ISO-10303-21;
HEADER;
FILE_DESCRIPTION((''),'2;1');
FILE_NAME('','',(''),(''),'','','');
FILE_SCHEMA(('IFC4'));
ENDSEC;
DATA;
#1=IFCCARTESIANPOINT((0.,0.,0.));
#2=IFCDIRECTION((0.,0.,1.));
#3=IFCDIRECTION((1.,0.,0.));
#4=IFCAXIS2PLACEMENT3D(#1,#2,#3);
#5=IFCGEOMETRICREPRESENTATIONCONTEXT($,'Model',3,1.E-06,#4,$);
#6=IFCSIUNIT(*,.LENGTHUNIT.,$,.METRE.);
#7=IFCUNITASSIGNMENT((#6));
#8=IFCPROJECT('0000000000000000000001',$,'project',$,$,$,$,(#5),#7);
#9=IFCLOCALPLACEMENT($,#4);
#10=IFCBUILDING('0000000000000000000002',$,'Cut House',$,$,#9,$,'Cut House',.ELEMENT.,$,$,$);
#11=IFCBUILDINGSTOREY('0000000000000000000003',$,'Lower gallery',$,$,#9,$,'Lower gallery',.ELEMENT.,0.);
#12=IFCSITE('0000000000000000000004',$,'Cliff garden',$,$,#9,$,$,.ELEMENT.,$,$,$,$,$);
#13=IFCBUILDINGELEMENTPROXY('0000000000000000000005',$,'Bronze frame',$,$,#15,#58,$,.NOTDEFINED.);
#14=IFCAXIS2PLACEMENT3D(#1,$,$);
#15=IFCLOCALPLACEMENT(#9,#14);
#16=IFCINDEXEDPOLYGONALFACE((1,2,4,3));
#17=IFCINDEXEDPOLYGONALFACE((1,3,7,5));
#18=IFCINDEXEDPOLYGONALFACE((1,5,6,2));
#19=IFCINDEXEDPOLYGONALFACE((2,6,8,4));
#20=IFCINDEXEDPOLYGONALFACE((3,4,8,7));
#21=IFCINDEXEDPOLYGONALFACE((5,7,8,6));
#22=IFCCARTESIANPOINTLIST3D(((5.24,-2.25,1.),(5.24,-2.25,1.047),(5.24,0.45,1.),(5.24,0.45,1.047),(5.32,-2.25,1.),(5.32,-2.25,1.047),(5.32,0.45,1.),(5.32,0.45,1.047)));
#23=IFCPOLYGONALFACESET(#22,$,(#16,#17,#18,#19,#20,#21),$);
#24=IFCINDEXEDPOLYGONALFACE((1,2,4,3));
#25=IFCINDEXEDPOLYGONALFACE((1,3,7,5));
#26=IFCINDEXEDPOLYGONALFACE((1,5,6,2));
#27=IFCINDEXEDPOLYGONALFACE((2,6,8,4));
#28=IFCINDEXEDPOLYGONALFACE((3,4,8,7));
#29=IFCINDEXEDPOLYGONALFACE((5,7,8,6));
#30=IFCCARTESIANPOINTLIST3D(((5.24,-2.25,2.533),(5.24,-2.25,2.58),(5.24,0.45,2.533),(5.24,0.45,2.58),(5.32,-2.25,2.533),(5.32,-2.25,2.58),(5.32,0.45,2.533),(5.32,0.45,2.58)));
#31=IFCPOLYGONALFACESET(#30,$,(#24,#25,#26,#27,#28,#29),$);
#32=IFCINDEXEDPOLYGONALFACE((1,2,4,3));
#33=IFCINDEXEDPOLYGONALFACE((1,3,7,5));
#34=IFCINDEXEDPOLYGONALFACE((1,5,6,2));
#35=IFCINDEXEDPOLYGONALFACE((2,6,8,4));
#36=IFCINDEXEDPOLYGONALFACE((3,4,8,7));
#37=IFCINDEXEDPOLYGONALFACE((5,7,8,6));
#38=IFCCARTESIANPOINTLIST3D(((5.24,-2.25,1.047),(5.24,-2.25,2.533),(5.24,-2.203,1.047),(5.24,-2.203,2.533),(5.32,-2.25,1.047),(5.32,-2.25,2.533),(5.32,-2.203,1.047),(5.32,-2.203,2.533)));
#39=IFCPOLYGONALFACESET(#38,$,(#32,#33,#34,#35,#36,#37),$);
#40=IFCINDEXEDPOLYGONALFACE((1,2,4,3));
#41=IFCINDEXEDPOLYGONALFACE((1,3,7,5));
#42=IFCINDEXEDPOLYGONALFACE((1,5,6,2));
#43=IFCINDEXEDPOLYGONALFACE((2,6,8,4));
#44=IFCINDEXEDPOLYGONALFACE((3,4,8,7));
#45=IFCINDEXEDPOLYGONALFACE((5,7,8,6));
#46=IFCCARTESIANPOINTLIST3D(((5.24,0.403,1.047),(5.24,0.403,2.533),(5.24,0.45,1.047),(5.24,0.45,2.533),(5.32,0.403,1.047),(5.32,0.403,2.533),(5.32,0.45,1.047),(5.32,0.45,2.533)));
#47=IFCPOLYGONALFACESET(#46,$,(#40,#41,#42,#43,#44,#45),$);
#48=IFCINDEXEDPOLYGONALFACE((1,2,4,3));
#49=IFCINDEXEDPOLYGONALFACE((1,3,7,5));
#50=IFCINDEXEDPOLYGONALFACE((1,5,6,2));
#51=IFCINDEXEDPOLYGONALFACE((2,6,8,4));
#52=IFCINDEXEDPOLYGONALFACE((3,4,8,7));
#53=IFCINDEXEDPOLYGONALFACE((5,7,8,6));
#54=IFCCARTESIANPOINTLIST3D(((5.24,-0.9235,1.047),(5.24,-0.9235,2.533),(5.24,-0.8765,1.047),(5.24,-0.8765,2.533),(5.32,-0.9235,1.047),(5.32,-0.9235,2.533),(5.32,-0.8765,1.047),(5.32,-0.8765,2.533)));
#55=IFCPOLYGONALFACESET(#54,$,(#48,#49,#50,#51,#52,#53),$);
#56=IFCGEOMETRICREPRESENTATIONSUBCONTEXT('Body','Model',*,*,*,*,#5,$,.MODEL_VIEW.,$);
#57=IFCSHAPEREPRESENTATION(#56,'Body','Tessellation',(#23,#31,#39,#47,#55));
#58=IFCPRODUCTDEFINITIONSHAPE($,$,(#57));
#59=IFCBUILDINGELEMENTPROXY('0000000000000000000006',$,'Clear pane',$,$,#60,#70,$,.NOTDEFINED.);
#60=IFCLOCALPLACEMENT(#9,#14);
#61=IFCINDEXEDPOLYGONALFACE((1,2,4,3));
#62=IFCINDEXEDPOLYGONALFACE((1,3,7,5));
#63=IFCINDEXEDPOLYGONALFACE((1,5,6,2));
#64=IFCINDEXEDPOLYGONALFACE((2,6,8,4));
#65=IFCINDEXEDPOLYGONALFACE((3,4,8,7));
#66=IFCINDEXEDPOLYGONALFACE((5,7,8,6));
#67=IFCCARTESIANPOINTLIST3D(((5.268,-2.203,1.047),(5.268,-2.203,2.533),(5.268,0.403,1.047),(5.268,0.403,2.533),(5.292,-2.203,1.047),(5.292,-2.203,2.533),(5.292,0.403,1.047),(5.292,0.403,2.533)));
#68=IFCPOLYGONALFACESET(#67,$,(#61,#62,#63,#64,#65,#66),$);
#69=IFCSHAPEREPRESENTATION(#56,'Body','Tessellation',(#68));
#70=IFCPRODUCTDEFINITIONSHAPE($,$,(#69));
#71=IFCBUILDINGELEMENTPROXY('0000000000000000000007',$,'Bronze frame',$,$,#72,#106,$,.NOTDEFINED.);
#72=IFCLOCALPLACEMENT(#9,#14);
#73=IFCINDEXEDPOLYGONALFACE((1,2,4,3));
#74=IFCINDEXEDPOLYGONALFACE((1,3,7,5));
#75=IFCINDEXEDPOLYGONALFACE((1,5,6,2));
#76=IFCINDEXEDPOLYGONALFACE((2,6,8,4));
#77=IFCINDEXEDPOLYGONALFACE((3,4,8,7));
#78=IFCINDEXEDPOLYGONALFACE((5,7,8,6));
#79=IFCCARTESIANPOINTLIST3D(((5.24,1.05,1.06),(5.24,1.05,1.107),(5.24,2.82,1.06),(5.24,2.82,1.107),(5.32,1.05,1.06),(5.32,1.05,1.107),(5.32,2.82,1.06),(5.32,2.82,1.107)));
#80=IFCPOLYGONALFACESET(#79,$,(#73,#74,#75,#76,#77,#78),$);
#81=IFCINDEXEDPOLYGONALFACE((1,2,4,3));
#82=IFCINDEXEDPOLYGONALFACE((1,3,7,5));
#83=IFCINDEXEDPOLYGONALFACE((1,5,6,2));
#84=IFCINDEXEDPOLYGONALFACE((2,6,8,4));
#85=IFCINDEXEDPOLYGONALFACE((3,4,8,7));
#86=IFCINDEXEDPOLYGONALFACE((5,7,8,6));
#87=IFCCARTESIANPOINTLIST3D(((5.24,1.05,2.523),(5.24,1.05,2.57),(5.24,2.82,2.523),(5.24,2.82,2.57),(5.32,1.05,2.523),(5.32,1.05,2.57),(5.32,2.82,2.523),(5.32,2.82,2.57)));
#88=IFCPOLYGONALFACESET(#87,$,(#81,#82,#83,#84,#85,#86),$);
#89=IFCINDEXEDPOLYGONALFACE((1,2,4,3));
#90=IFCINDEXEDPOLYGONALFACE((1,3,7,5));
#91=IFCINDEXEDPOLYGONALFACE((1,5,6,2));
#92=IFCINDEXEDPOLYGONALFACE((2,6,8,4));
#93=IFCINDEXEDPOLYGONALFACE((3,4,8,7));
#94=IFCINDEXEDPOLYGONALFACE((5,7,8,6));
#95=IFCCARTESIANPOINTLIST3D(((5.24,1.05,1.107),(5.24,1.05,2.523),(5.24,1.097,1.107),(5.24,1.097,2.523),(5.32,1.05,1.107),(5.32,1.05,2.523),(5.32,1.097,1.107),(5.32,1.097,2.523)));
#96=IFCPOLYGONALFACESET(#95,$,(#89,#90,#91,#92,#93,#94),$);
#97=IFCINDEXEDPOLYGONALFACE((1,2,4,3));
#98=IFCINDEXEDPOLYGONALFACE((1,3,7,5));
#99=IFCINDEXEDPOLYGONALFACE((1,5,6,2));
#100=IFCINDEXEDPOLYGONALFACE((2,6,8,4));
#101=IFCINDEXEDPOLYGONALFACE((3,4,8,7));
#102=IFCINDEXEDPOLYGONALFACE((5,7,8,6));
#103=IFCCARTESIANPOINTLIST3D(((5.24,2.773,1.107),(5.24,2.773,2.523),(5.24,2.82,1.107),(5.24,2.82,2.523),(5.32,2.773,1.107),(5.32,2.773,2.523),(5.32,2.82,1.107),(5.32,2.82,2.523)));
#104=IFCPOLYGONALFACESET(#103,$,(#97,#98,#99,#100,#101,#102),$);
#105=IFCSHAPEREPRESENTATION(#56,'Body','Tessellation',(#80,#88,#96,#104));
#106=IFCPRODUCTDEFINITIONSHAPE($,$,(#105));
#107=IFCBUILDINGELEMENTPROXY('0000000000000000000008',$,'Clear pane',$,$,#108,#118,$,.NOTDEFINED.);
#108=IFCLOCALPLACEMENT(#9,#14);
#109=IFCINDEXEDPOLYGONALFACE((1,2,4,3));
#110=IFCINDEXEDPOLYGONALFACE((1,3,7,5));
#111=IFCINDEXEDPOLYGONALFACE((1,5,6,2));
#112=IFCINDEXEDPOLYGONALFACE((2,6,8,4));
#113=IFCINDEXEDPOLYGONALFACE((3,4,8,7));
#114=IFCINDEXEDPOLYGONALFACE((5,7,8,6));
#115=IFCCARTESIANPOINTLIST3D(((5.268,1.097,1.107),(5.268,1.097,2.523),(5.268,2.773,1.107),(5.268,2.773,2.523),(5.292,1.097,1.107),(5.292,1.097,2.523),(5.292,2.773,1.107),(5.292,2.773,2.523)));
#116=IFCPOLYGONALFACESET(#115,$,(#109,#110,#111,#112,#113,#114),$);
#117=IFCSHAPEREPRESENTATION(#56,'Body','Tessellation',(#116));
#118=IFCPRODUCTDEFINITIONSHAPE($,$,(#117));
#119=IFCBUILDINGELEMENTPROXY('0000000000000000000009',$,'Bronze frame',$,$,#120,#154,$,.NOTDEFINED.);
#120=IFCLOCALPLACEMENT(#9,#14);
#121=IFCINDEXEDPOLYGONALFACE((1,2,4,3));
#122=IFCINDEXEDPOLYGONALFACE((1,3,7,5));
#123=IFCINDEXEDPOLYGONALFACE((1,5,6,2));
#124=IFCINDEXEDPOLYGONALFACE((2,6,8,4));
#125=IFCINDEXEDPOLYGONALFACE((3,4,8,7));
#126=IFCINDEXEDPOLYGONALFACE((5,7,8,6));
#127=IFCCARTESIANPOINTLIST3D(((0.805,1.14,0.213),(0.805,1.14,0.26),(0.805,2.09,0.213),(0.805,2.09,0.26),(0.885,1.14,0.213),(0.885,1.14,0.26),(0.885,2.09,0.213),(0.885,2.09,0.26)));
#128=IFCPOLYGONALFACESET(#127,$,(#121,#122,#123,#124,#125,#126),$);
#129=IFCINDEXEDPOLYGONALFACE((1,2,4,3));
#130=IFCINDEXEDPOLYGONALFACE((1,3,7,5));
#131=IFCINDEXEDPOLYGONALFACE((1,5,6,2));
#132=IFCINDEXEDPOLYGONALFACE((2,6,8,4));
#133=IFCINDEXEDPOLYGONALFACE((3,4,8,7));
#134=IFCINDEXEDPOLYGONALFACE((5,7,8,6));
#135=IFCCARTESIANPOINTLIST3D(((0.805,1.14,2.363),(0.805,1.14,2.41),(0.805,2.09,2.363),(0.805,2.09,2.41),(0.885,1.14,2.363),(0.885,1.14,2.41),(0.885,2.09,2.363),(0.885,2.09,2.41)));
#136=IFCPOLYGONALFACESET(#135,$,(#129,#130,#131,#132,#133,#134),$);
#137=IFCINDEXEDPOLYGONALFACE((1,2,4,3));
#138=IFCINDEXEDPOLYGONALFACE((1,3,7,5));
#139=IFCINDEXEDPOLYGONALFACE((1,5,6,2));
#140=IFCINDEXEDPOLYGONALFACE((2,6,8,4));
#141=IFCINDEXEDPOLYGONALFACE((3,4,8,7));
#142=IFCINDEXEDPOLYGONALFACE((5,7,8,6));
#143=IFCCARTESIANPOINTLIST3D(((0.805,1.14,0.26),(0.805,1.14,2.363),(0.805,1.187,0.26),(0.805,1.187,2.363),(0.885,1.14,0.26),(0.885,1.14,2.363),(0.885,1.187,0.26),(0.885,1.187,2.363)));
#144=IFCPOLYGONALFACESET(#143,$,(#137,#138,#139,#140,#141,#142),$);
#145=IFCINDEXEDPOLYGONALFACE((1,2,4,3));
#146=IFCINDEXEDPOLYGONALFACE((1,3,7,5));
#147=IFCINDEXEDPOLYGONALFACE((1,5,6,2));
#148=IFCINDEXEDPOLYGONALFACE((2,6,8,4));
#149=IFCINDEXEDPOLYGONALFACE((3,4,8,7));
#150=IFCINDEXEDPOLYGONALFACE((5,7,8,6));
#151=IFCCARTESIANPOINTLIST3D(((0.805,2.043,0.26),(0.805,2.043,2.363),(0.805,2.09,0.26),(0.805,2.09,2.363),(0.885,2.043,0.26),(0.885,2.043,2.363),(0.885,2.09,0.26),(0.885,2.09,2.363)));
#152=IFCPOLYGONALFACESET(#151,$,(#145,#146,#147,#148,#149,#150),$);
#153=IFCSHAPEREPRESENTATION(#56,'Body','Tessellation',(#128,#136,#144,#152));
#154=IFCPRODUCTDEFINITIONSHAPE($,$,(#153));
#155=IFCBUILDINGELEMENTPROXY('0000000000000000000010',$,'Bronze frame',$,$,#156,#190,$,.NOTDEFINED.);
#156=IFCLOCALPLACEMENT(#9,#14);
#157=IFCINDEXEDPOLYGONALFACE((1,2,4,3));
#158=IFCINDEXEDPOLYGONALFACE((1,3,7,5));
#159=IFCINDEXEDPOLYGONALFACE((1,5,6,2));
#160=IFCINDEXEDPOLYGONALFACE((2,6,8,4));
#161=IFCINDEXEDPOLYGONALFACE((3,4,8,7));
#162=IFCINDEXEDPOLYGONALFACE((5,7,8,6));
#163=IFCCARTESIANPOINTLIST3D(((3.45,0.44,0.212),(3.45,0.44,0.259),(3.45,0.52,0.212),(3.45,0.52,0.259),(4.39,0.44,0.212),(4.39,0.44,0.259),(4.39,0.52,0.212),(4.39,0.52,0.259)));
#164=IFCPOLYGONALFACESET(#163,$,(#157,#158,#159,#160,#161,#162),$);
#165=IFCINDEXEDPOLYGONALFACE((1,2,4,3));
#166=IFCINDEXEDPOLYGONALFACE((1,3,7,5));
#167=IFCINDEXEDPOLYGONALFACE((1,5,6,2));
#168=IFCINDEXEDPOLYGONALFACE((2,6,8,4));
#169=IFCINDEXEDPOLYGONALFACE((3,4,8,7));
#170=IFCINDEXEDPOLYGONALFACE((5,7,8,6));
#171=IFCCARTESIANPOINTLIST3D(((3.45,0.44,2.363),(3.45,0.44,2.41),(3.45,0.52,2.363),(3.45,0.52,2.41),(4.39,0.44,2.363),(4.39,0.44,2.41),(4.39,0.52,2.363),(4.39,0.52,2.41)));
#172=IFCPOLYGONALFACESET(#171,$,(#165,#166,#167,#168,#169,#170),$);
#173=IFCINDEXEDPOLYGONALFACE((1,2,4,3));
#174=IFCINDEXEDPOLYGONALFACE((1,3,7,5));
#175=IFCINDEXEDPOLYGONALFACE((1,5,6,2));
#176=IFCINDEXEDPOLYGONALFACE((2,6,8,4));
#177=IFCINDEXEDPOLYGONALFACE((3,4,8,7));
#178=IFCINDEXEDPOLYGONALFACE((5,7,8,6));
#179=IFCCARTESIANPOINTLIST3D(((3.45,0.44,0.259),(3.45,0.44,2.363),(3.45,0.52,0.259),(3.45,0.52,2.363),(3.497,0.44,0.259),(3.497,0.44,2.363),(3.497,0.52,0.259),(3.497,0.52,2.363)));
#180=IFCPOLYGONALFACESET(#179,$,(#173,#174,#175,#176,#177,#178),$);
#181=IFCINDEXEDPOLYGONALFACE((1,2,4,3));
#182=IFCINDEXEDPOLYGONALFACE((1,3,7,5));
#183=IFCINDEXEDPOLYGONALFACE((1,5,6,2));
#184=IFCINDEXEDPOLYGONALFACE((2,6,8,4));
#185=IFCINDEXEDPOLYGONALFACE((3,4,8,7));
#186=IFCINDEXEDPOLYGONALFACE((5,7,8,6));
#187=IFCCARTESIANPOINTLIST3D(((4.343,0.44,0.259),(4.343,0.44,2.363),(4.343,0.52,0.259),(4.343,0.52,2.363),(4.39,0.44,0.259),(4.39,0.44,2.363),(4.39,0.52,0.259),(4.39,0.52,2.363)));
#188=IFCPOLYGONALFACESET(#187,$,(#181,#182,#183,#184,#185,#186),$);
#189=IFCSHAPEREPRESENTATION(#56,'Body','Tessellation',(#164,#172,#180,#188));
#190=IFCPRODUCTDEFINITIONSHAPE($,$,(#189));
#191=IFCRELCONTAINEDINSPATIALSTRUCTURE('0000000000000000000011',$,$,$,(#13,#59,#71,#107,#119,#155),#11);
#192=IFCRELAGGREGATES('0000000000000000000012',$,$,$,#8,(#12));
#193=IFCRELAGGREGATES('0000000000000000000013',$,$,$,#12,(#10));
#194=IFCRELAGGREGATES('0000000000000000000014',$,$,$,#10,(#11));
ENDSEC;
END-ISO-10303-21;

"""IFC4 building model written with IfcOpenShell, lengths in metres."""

from ifc_helpers import new_model, si_unit, frame, origin_with_axes, place, context, subcontext, project, spatial, polyline, outline, extrude, element, save


model = new_model("IFC4")

# Units and contexts
model_context = context("Model", 3, precision=1e-06, world=origin_with_axes())
body_context = subcontext(model_context, "Body", "Model", "MODEL_VIEW")
ifc_project = project(units=[si_unit("LENGTHUNIT", "METRE")], contexts=[model_context])

# Site, building, storey
placement = place(None, origin_with_axes())
site = spatial("IfcSite", under=ifc_project, at=placement, Name="Cliff garden", CompositionType="ELEMENT")
building = spatial("IfcBuilding", under=site, at=placement, Name="Cut House", LongName="Cut House", CompositionType="ELEMENT")
storey = spatial("IfcBuildingStorey", under=building, at=placement, Name="Lower gallery", LongName="Lower gallery", CompositionType="ELEMENT", Elevation=0.0)

# Building element proxies
element("IfcBuildingElementProxy", 1, at=placement, inside=storey, Name="Bronze frame", PredefinedType="NOTDEFINED", context=body_context, shape_type="SweptSolid", body=[
    extrude(outline(polyline([(0.0, 0.0), (0.08, 0.0), (0.08, 2.7), (0.0, 2.7), (0.0, 0.0)])), frame((5.24, -2.25, 1.0), z_axis=(0.0, 0.0, 1.0), x_axis=(1.0, 0.0, 0.0)), (0.0, 0.0, 1.0), 0.047),
    extrude(outline(polyline([(0.0, 0.0), (0.08, 0.0), (0.08, 2.7), (0.0, 2.7), (0.0, 0.0)])), frame((5.24, -2.25, 2.533), z_axis=(0.0, 0.0, 1.0), x_axis=(1.0, 0.0, 0.0)), (0.0, 0.0, 1.0), 0.047),
    extrude(outline(polyline([(0.0, 0.0), (0.08, 0.0), (0.08, 0.047), (0.0, 0.047), (0.0, 0.0)])), frame((5.24, -2.25, 1.047), z_axis=(0.0, 0.0, 1.0), x_axis=(1.0, 0.0, 0.0)), (0.0, 0.0, 1.0), 1.486),
    extrude(outline(polyline([(0.0, 0.0), (0.08, 0.0), (0.08, 0.047), (0.0, 0.047), (0.0, 0.0)])), frame((5.24, 0.403, 1.047), z_axis=(0.0, 0.0, 1.0), x_axis=(1.0, 0.0, 0.0)), (0.0, 0.0, 1.0), 1.486),
    extrude(outline(polyline([(0.0, 0.0), (0.08, 0.0), (0.08, 0.047), (0.0, 0.047), (0.0, 0.0)])), frame((5.24, -0.9235, 1.047), z_axis=(0.0, 0.0, 1.0), x_axis=(1.0, 0.0, 0.0)), (0.0, 0.0, 1.0), 1.486),
])
element("IfcBuildingElementProxy", 2, at=placement, inside=storey, Name="Clear pane", PredefinedType="NOTDEFINED", context=body_context, shape_type="SweptSolid", body=[
    extrude(outline(polyline([(0.0, 0.0), (0.024, 0.0), (0.024, 2.606), (0.0, 2.606), (0.0, 0.0)])), frame((5.268, -2.203, 1.047), z_axis=(0.0, 0.0, 1.0), x_axis=(1.0, 0.0, 0.0)), (0.0, 0.0, 1.0), 1.486),
])
element("IfcBuildingElementProxy", 3, at=placement, inside=storey, Name="Bronze frame", PredefinedType="NOTDEFINED", context=body_context, shape_type="SweptSolid", body=[
    extrude(outline(polyline([(0.0, 0.0), (0.08, 0.0), (0.08, 1.77), (0.0, 1.77), (0.0, 0.0)])), frame((5.24, 1.05, 1.06), z_axis=(0.0, 0.0, 1.0), x_axis=(1.0, 0.0, 0.0)), (0.0, 0.0, 1.0), 0.047),
    extrude(outline(polyline([(0.0, 0.0), (0.08, 0.0), (0.08, 1.77), (0.0, 1.77), (0.0, 0.0)])), frame((5.24, 1.05, 2.523), z_axis=(0.0, 0.0, 1.0), x_axis=(1.0, 0.0, 0.0)), (0.0, 0.0, 1.0), 0.047),
    extrude(outline(polyline([(0.0, 0.0), (0.08, 0.0), (0.08, 0.047), (0.0, 0.047), (0.0, 0.0)])), frame((5.24, 1.05, 1.107), z_axis=(0.0, 0.0, 1.0), x_axis=(1.0, 0.0, 0.0)), (0.0, 0.0, 1.0), 1.416),
    extrude(outline(polyline([(0.0, 0.0), (0.08, 0.0), (0.08, 0.047), (0.0, 0.047), (0.0, 0.0)])), frame((5.24, 2.773, 1.107), z_axis=(0.0, 0.0, 1.0), x_axis=(1.0, 0.0, 0.0)), (0.0, 0.0, 1.0), 1.416),
])
element("IfcBuildingElementProxy", 4, at=placement, inside=storey, Name="Clear pane", PredefinedType="NOTDEFINED", context=body_context, shape_type="SweptSolid", body=[
    extrude(outline(polyline([(0.0, 0.0), (0.024, 0.0), (0.024, 1.676), (0.0, 1.676), (0.0, 0.0)])), frame((5.268, 1.097, 1.107), z_axis=(0.0, 0.0, 1.0), x_axis=(1.0, 0.0, 0.0)), (0.0, 0.0, 1.0), 1.416),
])
element("IfcBuildingElementProxy", 5, at=placement, inside=storey, Name="Bronze frame", PredefinedType="NOTDEFINED", context=body_context, shape_type="SweptSolid", body=[
    extrude(outline(polyline([(0.0, 0.0), (0.08, 0.0), (0.08, 0.95), (0.0, 0.95), (0.0, 0.0)])), frame((0.805, 1.14, 0.213), z_axis=(0.0, 0.0, 1.0), x_axis=(1.0, 0.0, 0.0)), (0.0, 0.0, 1.0), 0.047),
    extrude(outline(polyline([(0.0, 0.0), (0.08, 0.0), (0.08, 0.95), (0.0, 0.95), (0.0, 0.0)])), frame((0.805, 1.14, 2.363), z_axis=(0.0, 0.0, 1.0), x_axis=(1.0, 0.0, 0.0)), (0.0, 0.0, 1.0), 0.047),
    extrude(outline(polyline([(0.0, 0.0), (0.08, 0.0), (0.08, 0.047), (0.0, 0.047), (0.0, 0.0)])), frame((0.805, 1.14, 0.26), z_axis=(0.0, 0.0, 1.0), x_axis=(1.0, 0.0, 0.0)), (0.0, 0.0, 1.0), 2.103),
    extrude(outline(polyline([(0.0, 0.0), (0.08, 0.0), (0.08, 0.047), (0.0, 0.047), (0.0, 0.0)])), frame((0.805, 2.043, 0.26), z_axis=(0.0, 0.0, 1.0), x_axis=(1.0, 0.0, 0.0)), (0.0, 0.0, 1.0), 2.103),
])
element("IfcBuildingElementProxy", 6, at=placement, inside=storey, Name="Bronze frame", PredefinedType="NOTDEFINED", context=body_context, shape_type="SweptSolid", body=[
    extrude(outline(polyline([(0.0, 0.0), (0.94, 0.0), (0.94, 0.08), (0.0, 0.08), (0.0, 0.0)])), frame((3.45, 0.44, 0.212), z_axis=(0.0, 0.0, 1.0), x_axis=(1.0, 0.0, 0.0)), (0.0, 0.0, 1.0), 0.047),
    extrude(outline(polyline([(0.0, 0.0), (0.94, 0.0), (0.94, 0.08), (0.0, 0.08), (0.0, 0.0)])), frame((3.45, 0.44, 2.363), z_axis=(0.0, 0.0, 1.0), x_axis=(1.0, 0.0, 0.0)), (0.0, 0.0, 1.0), 0.047),
    extrude(outline(polyline([(0.0, 0.0), (0.047, 0.0), (0.047, 0.08), (0.0, 0.08), (0.0, 0.0)])), frame((3.45, 0.44, 0.259), z_axis=(0.0, 0.0, 1.0), x_axis=(1.0, 0.0, 0.0)), (0.0, 0.0, 1.0), 2.104),
    extrude(outline(polyline([(0.0, 0.0), (0.047, 0.0), (0.047, 0.08), (0.0, 0.08), (0.0, 0.0)])), frame((4.343, 0.44, 0.259), z_axis=(0.0, 0.0, 1.0), x_axis=(1.0, 0.0, 0.0)), (0.0, 0.0, 1.0), 2.104),
])

save(model, "model.ifc")
